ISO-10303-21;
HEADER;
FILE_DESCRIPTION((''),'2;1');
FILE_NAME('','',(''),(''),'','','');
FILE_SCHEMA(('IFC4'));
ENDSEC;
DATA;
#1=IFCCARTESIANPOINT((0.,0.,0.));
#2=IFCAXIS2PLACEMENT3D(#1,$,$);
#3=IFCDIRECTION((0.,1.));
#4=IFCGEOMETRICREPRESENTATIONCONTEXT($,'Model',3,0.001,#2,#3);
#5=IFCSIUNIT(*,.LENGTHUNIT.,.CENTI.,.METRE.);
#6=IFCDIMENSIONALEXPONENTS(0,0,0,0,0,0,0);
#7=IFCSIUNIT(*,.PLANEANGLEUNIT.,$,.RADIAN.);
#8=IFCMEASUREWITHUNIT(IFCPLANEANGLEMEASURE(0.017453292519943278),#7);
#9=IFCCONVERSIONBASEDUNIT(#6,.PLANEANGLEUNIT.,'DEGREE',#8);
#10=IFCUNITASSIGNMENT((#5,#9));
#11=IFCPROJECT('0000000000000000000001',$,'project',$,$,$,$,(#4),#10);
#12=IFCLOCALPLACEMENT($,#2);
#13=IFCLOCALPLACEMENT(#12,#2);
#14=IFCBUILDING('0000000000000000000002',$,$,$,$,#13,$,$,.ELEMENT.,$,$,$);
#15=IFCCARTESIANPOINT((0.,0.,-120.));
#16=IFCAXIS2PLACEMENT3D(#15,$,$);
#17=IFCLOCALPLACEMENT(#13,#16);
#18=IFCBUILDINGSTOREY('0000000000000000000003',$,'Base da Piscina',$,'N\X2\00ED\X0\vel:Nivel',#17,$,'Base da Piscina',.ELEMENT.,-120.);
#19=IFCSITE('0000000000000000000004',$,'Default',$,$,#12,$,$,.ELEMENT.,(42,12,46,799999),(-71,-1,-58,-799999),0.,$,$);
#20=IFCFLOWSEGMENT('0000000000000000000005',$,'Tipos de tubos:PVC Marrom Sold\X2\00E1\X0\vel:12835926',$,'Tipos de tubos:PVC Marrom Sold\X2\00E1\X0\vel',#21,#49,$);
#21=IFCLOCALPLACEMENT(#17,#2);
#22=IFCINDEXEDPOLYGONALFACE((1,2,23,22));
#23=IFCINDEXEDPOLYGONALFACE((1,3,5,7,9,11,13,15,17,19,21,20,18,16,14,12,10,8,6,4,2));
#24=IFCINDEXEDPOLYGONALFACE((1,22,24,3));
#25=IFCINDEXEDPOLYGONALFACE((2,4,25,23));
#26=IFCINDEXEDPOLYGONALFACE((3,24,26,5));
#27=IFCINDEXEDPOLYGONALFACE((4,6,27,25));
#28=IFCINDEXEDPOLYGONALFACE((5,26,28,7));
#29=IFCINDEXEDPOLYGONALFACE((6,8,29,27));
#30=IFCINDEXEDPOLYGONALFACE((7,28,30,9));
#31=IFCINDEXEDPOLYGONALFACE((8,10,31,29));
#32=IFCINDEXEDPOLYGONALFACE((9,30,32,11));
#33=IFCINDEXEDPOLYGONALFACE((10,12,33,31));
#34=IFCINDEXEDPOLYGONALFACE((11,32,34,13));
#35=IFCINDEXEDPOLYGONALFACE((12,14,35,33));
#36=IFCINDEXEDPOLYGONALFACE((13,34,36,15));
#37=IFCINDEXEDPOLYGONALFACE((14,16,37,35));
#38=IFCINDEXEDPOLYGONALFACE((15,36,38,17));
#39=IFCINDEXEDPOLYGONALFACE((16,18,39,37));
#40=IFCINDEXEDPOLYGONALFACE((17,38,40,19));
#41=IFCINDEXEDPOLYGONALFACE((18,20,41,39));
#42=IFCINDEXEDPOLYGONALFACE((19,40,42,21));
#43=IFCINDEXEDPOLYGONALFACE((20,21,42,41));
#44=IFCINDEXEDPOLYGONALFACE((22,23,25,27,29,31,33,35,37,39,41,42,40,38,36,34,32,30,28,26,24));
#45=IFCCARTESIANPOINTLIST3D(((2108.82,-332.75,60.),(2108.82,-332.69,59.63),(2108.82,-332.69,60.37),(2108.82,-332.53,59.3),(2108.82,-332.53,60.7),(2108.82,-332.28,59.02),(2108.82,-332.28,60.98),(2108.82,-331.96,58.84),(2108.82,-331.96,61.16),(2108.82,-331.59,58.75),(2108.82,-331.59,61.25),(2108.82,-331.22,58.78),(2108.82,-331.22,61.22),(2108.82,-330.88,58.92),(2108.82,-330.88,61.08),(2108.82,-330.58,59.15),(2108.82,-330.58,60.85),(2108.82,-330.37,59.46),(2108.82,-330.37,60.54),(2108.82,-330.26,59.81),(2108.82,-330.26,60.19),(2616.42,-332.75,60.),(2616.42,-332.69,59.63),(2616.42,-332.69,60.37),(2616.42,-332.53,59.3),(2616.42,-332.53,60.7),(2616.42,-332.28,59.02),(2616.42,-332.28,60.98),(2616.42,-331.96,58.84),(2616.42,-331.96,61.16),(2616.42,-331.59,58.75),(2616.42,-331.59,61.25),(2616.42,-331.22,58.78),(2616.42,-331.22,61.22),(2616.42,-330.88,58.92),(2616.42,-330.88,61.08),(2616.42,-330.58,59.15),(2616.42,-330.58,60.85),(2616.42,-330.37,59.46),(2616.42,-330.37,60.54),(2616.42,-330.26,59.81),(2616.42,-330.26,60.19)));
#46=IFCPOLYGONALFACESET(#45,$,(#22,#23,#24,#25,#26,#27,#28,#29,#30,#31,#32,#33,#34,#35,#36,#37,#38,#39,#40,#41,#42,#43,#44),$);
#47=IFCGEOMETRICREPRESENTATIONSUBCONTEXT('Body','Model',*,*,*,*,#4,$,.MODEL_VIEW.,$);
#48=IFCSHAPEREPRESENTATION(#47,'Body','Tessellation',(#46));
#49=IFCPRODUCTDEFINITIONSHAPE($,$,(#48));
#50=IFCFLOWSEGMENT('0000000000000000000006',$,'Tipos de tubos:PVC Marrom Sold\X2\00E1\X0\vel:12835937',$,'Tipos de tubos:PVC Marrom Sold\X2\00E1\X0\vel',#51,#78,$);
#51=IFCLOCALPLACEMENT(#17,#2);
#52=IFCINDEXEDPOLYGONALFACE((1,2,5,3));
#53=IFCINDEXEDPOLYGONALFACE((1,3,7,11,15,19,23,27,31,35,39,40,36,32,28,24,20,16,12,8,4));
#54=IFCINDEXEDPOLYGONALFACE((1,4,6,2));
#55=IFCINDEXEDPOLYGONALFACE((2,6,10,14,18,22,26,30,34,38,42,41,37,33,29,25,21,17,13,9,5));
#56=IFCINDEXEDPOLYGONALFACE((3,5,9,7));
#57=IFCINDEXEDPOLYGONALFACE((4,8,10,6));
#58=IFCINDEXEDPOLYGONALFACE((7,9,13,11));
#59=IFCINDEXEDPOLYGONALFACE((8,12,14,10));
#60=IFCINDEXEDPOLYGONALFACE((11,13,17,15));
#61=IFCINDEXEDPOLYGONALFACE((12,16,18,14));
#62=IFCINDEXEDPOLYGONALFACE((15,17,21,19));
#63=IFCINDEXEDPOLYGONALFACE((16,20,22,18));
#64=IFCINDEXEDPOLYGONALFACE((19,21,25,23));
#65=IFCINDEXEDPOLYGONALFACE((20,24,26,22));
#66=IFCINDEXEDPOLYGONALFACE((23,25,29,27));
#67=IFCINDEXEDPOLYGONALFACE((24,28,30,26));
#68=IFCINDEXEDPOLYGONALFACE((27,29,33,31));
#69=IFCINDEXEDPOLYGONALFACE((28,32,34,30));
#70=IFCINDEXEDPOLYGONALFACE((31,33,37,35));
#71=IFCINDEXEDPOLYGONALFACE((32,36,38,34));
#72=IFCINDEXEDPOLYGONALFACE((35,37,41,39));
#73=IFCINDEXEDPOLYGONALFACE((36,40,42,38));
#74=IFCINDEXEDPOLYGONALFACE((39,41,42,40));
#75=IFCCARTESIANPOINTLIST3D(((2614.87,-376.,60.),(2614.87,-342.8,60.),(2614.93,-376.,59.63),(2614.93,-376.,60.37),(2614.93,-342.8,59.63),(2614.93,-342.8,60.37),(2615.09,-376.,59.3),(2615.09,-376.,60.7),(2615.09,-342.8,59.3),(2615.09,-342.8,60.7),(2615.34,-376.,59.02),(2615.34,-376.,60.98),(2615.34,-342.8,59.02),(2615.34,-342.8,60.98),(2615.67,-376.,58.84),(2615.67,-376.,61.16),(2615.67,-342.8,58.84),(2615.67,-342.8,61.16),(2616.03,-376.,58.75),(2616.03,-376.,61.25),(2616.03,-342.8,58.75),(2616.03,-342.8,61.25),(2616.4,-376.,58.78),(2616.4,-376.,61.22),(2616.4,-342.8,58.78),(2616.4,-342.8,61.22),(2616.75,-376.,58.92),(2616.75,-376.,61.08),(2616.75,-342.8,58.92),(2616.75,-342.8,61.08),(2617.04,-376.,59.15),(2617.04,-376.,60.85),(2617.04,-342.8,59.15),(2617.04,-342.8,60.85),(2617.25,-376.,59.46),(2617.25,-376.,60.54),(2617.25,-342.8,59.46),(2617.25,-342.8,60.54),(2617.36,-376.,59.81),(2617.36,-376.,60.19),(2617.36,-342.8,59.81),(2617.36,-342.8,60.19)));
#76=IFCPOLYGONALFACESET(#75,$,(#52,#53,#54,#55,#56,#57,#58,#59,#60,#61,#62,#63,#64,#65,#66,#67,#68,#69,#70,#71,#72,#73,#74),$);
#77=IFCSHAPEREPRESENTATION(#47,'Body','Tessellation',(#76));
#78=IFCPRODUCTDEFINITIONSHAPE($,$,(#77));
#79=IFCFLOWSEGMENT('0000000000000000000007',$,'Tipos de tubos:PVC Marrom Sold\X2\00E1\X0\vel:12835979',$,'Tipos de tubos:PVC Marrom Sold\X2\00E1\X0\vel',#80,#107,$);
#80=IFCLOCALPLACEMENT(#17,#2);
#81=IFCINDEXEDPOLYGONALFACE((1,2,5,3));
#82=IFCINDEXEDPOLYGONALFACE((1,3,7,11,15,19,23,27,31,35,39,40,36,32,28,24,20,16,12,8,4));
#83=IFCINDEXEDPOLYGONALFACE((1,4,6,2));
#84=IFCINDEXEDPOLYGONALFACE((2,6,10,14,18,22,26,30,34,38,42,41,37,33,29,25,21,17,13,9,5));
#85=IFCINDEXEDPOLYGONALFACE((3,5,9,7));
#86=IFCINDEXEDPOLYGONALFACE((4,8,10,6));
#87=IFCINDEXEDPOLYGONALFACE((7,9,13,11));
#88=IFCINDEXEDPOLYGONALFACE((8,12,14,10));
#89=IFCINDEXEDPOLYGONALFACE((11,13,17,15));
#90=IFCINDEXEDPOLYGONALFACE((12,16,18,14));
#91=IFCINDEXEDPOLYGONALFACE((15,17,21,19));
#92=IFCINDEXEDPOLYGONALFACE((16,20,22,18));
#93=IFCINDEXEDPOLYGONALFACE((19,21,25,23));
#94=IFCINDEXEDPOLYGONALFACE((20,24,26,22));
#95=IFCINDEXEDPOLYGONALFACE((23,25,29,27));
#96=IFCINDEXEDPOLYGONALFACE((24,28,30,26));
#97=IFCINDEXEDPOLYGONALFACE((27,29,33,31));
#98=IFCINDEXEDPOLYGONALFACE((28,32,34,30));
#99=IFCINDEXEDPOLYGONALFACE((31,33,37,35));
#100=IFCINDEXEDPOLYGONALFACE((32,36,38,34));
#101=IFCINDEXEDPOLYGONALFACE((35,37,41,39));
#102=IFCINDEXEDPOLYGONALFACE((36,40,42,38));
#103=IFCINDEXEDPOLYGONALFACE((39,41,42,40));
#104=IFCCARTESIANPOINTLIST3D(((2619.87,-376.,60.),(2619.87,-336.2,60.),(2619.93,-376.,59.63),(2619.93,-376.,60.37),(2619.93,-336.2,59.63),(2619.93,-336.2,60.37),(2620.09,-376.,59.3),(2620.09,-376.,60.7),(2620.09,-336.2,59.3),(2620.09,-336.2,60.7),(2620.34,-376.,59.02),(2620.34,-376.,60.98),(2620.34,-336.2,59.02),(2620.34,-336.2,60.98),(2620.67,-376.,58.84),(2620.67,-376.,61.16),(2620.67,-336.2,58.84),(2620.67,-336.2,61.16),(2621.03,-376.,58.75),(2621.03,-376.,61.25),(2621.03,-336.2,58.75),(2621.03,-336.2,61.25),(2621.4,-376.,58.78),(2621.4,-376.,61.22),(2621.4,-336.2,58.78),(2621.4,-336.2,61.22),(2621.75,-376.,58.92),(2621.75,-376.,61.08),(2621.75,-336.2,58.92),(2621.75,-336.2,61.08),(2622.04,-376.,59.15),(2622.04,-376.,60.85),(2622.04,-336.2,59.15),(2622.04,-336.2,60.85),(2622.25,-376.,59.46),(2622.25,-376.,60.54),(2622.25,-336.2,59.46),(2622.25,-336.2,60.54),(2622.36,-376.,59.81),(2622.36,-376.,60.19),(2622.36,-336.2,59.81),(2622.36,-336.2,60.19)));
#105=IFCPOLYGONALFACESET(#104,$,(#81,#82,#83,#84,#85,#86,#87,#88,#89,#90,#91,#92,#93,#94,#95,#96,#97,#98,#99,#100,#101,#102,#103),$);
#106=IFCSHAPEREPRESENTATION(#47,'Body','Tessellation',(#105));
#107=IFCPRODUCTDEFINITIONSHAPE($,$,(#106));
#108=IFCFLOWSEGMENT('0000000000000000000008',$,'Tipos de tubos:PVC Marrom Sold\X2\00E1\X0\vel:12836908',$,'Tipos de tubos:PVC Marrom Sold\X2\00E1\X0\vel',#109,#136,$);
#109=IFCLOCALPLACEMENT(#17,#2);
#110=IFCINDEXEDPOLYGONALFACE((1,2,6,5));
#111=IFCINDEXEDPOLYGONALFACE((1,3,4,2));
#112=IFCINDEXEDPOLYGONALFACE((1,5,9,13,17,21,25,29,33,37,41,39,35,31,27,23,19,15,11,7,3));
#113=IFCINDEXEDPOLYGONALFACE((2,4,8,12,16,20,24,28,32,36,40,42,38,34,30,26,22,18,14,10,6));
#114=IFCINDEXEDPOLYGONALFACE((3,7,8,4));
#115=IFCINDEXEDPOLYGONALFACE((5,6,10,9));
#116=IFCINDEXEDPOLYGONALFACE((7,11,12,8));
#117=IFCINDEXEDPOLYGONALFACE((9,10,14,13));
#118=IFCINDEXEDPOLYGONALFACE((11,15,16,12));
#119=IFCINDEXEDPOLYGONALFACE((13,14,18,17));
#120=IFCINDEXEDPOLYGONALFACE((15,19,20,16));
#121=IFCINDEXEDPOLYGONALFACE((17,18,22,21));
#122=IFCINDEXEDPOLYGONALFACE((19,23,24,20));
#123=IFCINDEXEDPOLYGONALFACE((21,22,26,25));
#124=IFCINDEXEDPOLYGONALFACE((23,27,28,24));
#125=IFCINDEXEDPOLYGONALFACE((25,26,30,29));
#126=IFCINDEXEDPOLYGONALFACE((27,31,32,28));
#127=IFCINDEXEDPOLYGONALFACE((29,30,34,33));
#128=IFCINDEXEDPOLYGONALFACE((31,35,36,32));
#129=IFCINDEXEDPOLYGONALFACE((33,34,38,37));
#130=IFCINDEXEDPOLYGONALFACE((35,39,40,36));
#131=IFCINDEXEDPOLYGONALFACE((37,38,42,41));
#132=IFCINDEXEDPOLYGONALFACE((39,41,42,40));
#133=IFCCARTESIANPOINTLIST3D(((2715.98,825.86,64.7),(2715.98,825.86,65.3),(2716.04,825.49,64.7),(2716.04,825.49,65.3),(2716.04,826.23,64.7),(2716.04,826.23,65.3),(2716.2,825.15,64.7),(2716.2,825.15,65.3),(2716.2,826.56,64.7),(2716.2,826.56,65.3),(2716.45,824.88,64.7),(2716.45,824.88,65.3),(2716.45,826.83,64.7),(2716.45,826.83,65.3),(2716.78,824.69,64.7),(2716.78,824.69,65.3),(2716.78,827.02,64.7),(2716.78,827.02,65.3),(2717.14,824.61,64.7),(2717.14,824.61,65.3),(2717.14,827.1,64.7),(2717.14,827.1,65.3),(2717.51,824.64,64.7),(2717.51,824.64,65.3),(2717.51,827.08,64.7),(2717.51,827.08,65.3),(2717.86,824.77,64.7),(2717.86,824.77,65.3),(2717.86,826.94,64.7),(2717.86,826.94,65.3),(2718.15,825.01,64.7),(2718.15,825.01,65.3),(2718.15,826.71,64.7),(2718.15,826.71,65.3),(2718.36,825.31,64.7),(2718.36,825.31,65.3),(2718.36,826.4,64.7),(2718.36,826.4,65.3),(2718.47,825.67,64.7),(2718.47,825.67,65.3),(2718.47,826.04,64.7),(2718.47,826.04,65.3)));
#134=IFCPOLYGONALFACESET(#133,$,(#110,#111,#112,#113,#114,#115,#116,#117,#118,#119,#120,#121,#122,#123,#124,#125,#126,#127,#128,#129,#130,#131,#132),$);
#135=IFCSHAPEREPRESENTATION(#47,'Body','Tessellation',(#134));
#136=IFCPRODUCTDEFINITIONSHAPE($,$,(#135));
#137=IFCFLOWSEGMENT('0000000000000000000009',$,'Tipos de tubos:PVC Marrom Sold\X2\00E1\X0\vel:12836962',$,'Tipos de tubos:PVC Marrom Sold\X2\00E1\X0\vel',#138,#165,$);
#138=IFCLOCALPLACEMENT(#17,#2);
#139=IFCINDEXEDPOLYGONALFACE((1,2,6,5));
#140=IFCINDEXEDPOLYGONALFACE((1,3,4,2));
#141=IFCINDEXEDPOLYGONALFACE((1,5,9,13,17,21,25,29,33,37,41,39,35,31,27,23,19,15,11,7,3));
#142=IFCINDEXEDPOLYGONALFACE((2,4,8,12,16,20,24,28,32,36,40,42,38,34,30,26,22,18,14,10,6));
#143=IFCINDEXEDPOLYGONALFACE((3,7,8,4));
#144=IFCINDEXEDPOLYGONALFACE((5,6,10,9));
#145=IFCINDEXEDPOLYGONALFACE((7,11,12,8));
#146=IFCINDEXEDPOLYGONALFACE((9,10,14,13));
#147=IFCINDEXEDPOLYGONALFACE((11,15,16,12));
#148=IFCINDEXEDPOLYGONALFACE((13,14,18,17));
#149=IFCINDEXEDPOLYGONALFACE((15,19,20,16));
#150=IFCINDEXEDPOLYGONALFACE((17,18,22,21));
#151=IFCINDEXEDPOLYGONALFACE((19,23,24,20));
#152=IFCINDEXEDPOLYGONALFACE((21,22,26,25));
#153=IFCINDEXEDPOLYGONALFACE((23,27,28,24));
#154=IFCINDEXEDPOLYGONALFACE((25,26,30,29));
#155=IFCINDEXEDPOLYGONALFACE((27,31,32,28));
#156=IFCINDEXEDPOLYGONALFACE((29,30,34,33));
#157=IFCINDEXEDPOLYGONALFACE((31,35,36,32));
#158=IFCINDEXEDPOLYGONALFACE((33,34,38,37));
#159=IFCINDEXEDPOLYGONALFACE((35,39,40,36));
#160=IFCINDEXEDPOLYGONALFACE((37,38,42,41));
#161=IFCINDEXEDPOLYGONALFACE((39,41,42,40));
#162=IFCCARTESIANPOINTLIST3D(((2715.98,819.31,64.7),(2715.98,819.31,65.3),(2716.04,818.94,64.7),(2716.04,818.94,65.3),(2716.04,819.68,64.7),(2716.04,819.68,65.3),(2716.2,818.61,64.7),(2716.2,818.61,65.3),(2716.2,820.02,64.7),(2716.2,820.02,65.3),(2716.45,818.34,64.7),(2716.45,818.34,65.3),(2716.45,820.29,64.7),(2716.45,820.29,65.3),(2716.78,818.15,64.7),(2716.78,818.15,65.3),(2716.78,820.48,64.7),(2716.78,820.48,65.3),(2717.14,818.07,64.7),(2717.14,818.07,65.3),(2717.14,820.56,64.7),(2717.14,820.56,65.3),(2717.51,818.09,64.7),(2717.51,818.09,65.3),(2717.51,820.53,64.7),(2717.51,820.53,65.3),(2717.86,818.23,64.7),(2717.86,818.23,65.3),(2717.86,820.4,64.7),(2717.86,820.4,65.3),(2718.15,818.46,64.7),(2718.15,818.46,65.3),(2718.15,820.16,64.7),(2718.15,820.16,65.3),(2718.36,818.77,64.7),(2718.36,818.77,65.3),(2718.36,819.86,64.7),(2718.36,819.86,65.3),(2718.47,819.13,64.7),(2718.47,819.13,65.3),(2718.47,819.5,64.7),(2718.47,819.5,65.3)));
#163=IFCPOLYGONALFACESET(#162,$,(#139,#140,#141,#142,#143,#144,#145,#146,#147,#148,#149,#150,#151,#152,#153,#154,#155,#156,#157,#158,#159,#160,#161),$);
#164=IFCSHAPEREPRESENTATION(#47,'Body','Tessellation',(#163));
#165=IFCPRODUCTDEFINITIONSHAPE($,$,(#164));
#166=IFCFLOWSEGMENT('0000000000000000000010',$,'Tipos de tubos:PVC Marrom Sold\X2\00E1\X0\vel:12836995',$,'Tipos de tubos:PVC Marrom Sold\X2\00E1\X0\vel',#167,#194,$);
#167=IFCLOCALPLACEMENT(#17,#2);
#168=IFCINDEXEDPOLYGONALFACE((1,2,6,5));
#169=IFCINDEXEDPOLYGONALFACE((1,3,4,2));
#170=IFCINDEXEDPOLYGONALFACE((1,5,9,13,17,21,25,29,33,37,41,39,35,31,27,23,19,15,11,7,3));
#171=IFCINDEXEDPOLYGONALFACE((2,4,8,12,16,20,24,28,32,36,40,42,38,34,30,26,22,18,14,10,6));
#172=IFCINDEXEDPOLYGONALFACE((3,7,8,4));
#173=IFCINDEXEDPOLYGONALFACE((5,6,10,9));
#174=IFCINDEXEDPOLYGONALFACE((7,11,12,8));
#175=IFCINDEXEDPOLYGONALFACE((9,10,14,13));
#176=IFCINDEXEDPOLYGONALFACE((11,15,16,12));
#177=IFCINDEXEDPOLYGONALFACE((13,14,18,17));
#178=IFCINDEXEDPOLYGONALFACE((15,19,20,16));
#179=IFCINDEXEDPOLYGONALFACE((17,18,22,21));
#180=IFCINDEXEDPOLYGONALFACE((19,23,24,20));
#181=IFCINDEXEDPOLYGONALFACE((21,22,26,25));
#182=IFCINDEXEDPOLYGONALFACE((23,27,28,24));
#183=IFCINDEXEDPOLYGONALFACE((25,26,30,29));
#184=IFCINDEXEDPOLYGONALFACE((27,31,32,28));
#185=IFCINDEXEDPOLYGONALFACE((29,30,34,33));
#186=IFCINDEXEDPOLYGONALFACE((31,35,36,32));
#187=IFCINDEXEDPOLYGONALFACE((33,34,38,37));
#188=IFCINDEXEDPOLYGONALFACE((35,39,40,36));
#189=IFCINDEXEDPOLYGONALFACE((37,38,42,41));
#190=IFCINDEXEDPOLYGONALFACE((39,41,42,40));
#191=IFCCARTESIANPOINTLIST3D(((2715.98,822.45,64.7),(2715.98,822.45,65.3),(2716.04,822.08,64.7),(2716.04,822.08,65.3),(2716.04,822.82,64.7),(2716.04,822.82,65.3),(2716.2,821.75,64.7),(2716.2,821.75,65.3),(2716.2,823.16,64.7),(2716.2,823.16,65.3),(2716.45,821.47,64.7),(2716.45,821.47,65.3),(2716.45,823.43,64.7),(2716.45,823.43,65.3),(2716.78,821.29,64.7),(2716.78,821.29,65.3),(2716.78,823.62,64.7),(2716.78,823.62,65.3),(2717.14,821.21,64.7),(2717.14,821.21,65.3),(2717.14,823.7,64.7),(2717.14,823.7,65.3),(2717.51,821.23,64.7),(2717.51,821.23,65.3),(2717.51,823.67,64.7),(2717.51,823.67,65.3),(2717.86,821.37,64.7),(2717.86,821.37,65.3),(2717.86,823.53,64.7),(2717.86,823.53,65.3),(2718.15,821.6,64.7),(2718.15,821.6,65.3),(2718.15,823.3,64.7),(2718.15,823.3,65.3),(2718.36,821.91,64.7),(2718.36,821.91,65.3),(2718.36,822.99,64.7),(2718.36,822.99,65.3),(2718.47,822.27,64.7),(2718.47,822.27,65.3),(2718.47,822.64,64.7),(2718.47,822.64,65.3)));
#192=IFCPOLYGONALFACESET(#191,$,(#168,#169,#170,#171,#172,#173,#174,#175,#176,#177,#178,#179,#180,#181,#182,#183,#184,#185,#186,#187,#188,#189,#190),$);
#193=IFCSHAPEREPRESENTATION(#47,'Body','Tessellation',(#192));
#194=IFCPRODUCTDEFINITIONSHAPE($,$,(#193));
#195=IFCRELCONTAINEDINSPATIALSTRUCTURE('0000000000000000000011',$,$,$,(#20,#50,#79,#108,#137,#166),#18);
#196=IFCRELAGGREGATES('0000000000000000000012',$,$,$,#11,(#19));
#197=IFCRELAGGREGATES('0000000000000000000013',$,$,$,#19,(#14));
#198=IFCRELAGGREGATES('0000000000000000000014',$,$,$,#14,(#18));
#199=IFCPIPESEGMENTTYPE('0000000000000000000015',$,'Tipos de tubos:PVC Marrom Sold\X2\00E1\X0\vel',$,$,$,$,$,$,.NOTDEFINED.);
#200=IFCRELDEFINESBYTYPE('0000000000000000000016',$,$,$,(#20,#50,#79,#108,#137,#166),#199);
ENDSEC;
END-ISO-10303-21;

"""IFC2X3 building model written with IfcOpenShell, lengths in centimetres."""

from ifc_helpers import new_model, entity, si_unit, converted_unit, direction, frame, frame_2d, origin, origin_2d_with_axis, place, context, subcontext, project, spatial, circle, extrude, type_object, element, save


model = new_model("IFC2X3")

# Units and contexts
model_context = context("Model", 3, precision=0.001, world=origin(), true_north=direction((0.0, 1.0)))
body_context = subcontext(model_context, "Body", "Model", "MODEL_VIEW")
ifc_project = project(units=[si_unit("LENGTHUNIT", "METRE", prefix="CENTI"), converted_unit("PLANEANGLEUNIT", "DEGREE", entity("IfcPlaneAngleMeasure", 0.017453292519943278), si_unit("PLANEANGLEUNIT", "RADIAN"), dimensions=[0, 0, 0, 0, 0, 0, 0])], contexts=[model_context])

# Site, building, storey
site_placement = place(None, origin())
site = spatial("IfcSite", under=ifc_project, at=site_placement, Name="Default", CompositionType="ELEMENT", RefLatitude=(42, 12, 46, 799999), RefLongitude=(-71, -1, -58, -799999), RefElevation=0.0)
building_placement = place(site_placement, origin())
building = spatial("IfcBuilding", under=site, at=building_placement, CompositionType="ELEMENT")
storey_placement = place(building_placement, frame((0.0, 0.0, -120.0)))
storey = spatial("IfcBuildingStorey", under=building, at=storey_placement, Name="Base da Piscina", ObjectType="Nível:Nivel", LongName="Base da Piscina", CompositionType="ELEMENT", Elevation=-120.0)

# Flow segments
pipe_segment_type = type_object("IfcPipeSegmentType", Name="Tipos de tubos:PVC Marrom Soldável", PredefinedType="NOTDEFINED")
flow_segment_1_placement = place(storey_placement, origin())
element("IfcFlowSegment", 1, at=flow_segment_1_placement, inside=storey, type_object=pipe_segment_type, Name="Tipos de tubos:PVC Marrom Soldável:12835926", ObjectType="Tipos de tubos:PVC Marrom Soldável", context=body_context, shape_type="SweptSolid", body=[
    extrude(circle(Radius=1.25, at=origin_2d_with_axis()), frame((2108.82, -331.5, 60.0), z_axis=(1.0, 0.0, 0.0), x_axis=(0.0, -1.0, 0.0)), (0.0, 0.0, 1.0), 507.6),
])
flow_segment_2_placement = place(storey_placement, origin())
element("IfcFlowSegment", 2, at=flow_segment_2_placement, inside=storey, type_object=pipe_segment_type, Name="Tipos de tubos:PVC Marrom Soldável:12835937", ObjectType="Tipos de tubos:PVC Marrom Soldável", context=body_context, shape_type="SweptSolid", body=[
    extrude(circle(Radius=1.25, at=origin_2d_with_axis()), frame((2616.12, -376.0, 60.0), z_axis=(0.0, 1.0, 0.0), x_axis=(-1.0, 0.0, 0.0)), (0.0, 0.0, 1.0), 33.2),
])
flow_segment_3_placement = place(storey_placement, origin())
element("IfcFlowSegment", 3, at=flow_segment_3_placement, inside=storey, type_object=pipe_segment_type, Name="Tipos de tubos:PVC Marrom Soldável:12835979", ObjectType="Tipos de tubos:PVC Marrom Soldável", context=body_context, shape_type="SweptSolid", body=[
    extrude(circle(Radius=1.25, at=origin_2d_with_axis()), frame((2621.12, -376.0, 60.0), z_axis=(0.0, 1.0, 0.0), x_axis=(-1.0, 0.0, 0.0)), (0.0, 0.0, 1.0), 39.8),
])
flow_segment_4_placement = place(storey_placement, origin())
element("IfcFlowSegment", 4, at=flow_segment_4_placement, inside=storey, type_object=pipe_segment_type, Name="Tipos de tubos:PVC Marrom Soldável:12836908", ObjectType="Tipos de tubos:PVC Marrom Soldável", context=body_context, shape_type="SweptSolid", body=[
    extrude(circle(Radius=1.25, at=frame_2d((0.0, 0.0), x_axis=(1.0, 0.0))), frame((2717.23, 825.86, 64.7), z_axis=(0.0, 0.0, 1.0), x_axis=(-1.0, 0.0, 0.0)), (0.0, 0.0, 1.0), 0.6),
])
flow_segment_5_placement = place(storey_placement, origin())
element("IfcFlowSegment", 5, at=flow_segment_5_placement, inside=storey, type_object=pipe_segment_type, Name="Tipos de tubos:PVC Marrom Soldável:12836962", ObjectType="Tipos de tubos:PVC Marrom Soldável", context=body_context, shape_type="SweptSolid", body=[
    extrude(circle(Radius=1.25, at=frame_2d((0.0, 0.0), x_axis=(1.0, 0.0))), frame((2717.23, 819.31, 64.7), z_axis=(0.0, 0.0, 1.0), x_axis=(-1.0, 0.0, 0.0)), (0.0, 0.0, 1.0), 0.6),
])
flow_segment_6_placement = place(storey_placement, origin())
element("IfcFlowSegment", 6, at=flow_segment_6_placement, inside=storey, type_object=pipe_segment_type, Name="Tipos de tubos:PVC Marrom Soldável:12836995", ObjectType="Tipos de tubos:PVC Marrom Soldável", context=body_context, shape_type="SweptSolid", body=[
    extrude(circle(Radius=1.25, at=frame_2d((0.0, 0.0), x_axis=(1.0, 0.0))), frame((2717.23, 822.45, 64.7), z_axis=(0.0, 0.0, 1.0), x_axis=(-1.0, 0.0, 0.0)), (0.0, 0.0, 1.0), 0.6),
])

save(model, "model.ifc")
